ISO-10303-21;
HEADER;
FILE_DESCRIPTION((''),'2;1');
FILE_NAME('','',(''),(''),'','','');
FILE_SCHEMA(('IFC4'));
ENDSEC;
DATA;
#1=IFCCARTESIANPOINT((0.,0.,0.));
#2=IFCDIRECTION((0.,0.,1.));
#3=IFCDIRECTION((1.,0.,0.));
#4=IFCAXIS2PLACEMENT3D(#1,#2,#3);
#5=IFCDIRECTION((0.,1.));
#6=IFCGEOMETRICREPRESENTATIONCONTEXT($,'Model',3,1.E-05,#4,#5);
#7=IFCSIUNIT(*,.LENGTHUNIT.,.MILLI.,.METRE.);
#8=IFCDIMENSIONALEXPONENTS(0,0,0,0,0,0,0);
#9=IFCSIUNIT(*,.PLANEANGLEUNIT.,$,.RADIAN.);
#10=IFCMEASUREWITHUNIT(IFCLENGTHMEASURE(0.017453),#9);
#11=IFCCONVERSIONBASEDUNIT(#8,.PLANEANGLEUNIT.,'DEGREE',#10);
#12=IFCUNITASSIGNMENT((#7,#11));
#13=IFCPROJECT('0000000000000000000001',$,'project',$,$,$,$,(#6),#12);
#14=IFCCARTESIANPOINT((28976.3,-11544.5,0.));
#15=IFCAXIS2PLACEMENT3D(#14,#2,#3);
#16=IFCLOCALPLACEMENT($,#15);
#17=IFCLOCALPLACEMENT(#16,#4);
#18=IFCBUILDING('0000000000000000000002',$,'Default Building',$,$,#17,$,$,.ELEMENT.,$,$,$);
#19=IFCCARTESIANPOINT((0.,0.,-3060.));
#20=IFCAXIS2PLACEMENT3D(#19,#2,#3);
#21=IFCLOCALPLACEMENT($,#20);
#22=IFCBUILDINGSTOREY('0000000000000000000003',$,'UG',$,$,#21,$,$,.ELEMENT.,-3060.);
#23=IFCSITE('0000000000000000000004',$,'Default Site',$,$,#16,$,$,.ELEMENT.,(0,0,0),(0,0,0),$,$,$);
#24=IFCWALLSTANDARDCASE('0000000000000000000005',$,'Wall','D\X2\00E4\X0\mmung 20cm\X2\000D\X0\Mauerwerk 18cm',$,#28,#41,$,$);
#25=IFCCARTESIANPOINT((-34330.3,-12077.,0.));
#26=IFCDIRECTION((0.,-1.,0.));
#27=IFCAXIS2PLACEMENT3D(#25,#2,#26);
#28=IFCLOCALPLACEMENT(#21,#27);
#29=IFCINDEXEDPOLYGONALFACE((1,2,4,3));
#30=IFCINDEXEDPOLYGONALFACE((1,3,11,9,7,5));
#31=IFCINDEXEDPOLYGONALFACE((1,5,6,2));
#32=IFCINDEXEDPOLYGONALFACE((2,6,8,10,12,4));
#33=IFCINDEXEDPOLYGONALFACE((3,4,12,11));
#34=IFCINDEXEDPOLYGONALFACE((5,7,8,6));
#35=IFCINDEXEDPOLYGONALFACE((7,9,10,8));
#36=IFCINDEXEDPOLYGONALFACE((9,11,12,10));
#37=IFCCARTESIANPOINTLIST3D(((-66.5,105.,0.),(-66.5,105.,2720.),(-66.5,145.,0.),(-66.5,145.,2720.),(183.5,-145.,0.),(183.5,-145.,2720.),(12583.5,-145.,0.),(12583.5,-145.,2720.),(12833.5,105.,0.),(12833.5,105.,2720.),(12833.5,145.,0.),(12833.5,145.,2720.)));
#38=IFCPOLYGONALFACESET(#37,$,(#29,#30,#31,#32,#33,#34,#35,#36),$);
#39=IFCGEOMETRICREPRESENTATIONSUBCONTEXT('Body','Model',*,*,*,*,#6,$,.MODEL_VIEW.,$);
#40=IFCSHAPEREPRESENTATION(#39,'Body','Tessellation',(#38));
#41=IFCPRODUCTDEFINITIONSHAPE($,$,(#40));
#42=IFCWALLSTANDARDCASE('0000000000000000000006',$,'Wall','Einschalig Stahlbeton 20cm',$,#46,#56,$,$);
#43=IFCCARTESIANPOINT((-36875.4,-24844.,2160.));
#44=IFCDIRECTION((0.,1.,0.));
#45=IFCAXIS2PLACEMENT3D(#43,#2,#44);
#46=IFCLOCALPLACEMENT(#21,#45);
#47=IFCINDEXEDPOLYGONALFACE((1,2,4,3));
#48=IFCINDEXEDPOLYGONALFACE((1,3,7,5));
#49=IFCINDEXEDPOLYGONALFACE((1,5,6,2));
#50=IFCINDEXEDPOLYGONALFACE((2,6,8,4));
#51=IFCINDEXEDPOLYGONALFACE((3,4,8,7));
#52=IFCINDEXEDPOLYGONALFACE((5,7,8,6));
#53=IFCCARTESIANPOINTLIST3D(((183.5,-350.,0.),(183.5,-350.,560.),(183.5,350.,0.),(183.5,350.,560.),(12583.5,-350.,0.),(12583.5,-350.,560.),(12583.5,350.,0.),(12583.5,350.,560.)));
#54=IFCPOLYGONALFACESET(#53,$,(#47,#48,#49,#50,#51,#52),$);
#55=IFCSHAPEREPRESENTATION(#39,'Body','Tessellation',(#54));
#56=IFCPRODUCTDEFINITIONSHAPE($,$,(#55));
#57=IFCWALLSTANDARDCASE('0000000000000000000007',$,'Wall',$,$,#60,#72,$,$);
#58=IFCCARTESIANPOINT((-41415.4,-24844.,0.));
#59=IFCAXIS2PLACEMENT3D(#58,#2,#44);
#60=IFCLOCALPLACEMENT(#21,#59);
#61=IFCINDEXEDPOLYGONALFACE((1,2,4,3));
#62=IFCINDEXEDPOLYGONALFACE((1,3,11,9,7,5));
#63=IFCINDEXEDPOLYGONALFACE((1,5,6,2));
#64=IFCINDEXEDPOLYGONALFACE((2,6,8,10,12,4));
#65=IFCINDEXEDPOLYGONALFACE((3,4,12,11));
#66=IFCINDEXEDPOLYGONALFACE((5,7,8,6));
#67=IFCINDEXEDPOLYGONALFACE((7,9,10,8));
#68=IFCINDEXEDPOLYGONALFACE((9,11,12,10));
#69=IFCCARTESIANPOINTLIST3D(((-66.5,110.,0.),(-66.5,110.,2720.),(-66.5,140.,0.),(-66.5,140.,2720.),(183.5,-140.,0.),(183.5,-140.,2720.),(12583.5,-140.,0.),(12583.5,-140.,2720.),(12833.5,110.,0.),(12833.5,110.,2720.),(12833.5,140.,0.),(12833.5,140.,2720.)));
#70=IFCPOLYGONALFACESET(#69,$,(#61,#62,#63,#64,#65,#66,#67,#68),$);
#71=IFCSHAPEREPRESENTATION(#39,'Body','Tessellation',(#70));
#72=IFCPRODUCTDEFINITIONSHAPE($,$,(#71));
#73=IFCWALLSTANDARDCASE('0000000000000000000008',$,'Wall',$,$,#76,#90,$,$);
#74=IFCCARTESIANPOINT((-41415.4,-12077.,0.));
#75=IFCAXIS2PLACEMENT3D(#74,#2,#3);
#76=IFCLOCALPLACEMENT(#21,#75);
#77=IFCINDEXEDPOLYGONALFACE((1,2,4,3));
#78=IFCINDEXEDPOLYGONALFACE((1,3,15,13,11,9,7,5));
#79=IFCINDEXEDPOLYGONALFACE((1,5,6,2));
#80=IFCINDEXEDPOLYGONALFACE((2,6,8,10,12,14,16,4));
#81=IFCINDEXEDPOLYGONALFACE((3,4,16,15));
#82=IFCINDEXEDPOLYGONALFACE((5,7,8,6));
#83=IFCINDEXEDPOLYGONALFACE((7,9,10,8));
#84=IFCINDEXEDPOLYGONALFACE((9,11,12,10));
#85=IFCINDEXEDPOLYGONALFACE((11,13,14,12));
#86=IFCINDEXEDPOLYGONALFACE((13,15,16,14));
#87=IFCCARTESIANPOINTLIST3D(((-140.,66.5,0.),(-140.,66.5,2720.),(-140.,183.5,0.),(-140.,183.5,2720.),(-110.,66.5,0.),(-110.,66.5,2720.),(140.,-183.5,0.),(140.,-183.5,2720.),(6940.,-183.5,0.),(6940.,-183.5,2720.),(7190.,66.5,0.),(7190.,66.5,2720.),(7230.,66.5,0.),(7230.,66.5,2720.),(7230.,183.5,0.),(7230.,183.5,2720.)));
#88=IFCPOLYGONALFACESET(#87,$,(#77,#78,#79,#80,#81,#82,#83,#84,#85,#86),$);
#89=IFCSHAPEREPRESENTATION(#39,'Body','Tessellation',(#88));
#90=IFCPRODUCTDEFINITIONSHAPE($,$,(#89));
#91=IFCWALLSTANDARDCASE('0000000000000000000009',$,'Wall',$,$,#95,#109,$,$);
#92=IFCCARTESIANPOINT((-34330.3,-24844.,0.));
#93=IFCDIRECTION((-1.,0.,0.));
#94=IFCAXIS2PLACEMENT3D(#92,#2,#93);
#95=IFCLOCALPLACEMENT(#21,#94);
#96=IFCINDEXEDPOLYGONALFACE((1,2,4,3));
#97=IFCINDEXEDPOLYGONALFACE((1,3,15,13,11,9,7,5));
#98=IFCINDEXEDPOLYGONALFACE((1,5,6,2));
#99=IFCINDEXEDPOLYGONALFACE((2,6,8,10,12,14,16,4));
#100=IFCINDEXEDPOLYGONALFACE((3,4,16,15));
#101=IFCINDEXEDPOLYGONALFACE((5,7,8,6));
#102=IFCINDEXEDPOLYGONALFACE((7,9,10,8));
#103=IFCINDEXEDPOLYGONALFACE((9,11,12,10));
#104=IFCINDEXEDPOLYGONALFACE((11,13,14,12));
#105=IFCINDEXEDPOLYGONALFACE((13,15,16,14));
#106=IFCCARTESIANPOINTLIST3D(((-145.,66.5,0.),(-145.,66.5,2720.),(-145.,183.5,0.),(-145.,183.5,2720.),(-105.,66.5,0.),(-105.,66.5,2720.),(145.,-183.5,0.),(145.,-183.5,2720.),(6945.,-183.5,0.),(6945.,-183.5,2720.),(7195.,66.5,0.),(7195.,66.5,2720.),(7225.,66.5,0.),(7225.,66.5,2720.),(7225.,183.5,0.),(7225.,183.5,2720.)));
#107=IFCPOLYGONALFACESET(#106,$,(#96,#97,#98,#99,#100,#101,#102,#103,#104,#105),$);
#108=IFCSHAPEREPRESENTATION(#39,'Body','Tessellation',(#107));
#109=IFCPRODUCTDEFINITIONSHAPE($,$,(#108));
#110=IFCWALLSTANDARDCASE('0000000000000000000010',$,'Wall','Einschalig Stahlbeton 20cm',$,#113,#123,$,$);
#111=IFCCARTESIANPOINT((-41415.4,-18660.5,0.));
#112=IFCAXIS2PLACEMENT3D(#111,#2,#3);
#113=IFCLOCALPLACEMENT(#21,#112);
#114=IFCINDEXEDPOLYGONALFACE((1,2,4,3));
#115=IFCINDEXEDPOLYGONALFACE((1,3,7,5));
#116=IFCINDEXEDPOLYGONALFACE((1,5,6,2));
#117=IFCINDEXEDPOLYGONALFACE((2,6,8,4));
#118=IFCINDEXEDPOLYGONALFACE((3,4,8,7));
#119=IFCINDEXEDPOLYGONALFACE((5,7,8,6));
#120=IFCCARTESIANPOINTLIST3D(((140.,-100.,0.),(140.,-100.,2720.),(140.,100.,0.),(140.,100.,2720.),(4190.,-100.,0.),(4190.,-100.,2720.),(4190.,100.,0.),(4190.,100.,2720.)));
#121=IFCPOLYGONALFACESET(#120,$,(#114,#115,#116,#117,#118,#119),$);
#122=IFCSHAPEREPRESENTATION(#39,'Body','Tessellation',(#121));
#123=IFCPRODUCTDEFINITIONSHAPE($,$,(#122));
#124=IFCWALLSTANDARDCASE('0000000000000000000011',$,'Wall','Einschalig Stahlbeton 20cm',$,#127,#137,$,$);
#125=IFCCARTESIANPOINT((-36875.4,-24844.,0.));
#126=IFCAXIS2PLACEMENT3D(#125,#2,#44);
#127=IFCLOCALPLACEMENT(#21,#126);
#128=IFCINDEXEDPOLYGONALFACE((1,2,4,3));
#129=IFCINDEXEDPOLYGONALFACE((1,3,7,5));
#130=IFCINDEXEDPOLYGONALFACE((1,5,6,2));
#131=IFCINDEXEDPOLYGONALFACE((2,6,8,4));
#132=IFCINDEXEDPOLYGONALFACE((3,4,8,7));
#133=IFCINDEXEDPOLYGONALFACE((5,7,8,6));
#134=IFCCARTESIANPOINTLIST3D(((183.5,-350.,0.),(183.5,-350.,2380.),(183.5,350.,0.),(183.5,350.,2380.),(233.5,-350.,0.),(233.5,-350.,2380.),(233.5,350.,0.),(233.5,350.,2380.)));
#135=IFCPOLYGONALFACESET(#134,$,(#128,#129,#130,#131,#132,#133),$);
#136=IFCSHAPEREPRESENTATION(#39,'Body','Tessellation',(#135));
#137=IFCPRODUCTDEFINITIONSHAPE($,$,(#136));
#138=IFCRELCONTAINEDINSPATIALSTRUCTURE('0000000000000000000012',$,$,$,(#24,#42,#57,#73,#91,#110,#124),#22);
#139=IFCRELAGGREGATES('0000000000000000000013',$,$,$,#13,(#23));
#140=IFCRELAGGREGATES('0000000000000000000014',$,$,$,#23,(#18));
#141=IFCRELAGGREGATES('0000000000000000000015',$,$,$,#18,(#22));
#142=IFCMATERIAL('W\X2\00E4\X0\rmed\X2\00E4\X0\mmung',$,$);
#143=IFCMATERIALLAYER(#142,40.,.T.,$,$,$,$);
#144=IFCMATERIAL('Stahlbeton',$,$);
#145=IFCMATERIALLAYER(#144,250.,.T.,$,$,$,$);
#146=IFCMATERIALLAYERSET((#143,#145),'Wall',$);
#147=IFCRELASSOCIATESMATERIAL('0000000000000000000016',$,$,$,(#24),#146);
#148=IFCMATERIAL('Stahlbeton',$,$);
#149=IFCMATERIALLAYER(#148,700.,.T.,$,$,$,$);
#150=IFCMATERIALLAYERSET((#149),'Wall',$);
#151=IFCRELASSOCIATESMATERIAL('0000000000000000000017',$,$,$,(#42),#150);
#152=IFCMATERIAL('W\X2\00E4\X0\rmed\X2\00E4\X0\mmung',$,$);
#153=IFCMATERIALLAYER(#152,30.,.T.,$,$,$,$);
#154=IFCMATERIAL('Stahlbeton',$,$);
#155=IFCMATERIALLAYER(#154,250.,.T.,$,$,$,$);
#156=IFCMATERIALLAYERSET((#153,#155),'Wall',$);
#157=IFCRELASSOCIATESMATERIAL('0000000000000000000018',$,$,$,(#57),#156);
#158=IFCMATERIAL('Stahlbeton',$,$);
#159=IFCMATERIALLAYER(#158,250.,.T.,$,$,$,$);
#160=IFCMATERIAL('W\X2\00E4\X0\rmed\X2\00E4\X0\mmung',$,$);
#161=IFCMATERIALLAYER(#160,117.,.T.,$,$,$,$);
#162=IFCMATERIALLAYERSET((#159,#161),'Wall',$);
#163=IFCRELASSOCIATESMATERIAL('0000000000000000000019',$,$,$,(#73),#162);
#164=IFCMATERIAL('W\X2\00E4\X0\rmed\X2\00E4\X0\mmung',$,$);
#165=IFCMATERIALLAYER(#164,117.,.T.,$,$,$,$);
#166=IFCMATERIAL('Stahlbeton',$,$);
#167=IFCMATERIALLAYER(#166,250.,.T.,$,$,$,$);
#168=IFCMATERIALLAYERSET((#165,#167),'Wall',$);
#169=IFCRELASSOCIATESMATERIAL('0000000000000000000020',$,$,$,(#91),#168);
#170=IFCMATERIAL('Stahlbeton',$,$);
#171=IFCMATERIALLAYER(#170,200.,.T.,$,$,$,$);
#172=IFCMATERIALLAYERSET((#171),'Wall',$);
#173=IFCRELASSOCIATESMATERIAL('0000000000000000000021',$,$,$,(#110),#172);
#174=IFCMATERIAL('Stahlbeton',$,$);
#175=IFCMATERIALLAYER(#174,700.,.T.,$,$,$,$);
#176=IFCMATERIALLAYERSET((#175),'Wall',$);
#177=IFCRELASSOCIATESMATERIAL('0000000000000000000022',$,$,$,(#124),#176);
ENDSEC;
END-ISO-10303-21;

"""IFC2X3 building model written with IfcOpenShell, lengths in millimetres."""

from ifc_helpers import new_model, entity, si_unit, converted_unit, direction, frame, origin_with_axes, place, context, subcontext, project, spatial, polyline, outline, extrude, material, layer, layer_set, layer_usage, element, save


model = new_model("IFC2X3")

# Units and contexts
model_context = context("Model", 3, precision=1e-05, world=origin_with_axes(), true_north=direction((0.0, 1.0)))
body_context = subcontext(model_context, "Body", "Model", "MODEL_VIEW")
ifc_project = project(units=[si_unit("LENGTHUNIT", "METRE", prefix="MILLI"), converted_unit("PLANEANGLEUNIT", "DEGREE", entity("IfcLengthMeasure", 0.017453), si_unit("PLANEANGLEUNIT", "RADIAN"), dimensions=[0, 0, 0, 0, 0, 0, 0])], contexts=[model_context])

# Site, building, storey
site_placement = place(None, frame((28976.3, -11544.5, 0.0), z_axis=(0.0, 0.0, 1.0), x_axis=(1.0, 0.0, 0.0)))
site = spatial("IfcSite", under=ifc_project, at=site_placement, Name="Default Site", CompositionType="ELEMENT", RefLatitude=(0, 0, 0), RefLongitude=(0, 0, 0))
building_placement = place(site_placement, origin_with_axes())
building = spatial("IfcBuilding", under=site, at=building_placement, Name="Default Building", CompositionType="ELEMENT")
storey_placement = place(None, frame((0.0, 0.0, -3060.0), z_axis=(0.0, 0.0, 1.0), x_axis=(1.0, 0.0, 0.0)))
storey = spatial("IfcBuildingStorey", under=building, at=storey_placement, Name="UG", CompositionType="ELEMENT", Elevation=-3060.0)

# Walls
ifc_material_1 = material(Name="Wärmedämmung")
ifc_layer_1 = layer(ifc_material_1, 40.0, ventilated=True)
ifc_material_2 = material(Name="Stahlbeton")
ifc_layer_2 = layer(ifc_material_2, 250.0, ventilated=True)
ifc_layer_set_1 = layer_set([ifc_layer_1, ifc_layer_2], Name="Wall")
ifc_layer_usage_1 = layer_usage(ifc_layer_set_1, "AXIS2", "POSITIVE", -145.0)
wall_1_placement = place(storey_placement, frame((-34330.3, -12077.0, 0.0), z_axis=(0.0, 0.0, 1.0), x_axis=(0.0, -1.0, 0.0)))
element("IfcWallStandardCase", 1, at=wall_1_placement, inside=storey, material=ifc_layer_usage_1, Name="Wall", Description="Dämmung 20cm\rMauerwerk 18cm", context=body_context, shape_type="SweptSolid", body=[
    extrude(outline(polyline([(12833.5, 105.0), (12833.5, 145.0), (-66.5, 145.0), (-66.5, 105.0), (183.5, -145.0), (12583.5, -145.0), (12833.5, 105.0)])), origin_with_axes(), (0.0, 0.0, 1.0), 2720.0),
])
ifc_material_3 = material(Name="Stahlbeton")
ifc_layer_3 = layer(ifc_material_3, 700.0, ventilated=True)
ifc_layer_set_2 = layer_set([ifc_layer_3], Name="Wall")
ifc_layer_usage_2 = layer_usage(ifc_layer_set_2, "AXIS2", "POSITIVE", -350.0)
wall_2_placement = place(storey_placement, frame((-36875.4, -24844.0, 2160.0), z_axis=(0.0, 0.0, 1.0), x_axis=(0.0, 1.0, 0.0)))
element("IfcWallStandardCase", 2, at=wall_2_placement, inside=storey, material=ifc_layer_usage_2, Name="Wall", Description="Einschalig Stahlbeton 20cm", context=body_context, shape_type="SweptSolid", body=[
    extrude(outline(polyline([(183.5, -350.0), (183.5, 350.0), (12583.5, 350.0), (12583.5, -350.0), (183.5, -350.0)])), origin_with_axes(), (0.0, 0.0, 1.0), 560.0),
])
ifc_material_4 = material(Name="Wärmedämmung")
ifc_layer_4 = layer(ifc_material_4, 30.0, ventilated=True)
ifc_material_5 = material(Name="Stahlbeton")
ifc_layer_5 = layer(ifc_material_5, 250.0, ventilated=True)
ifc_layer_set_3 = layer_set([ifc_layer_4, ifc_layer_5], Name="Wall")
ifc_layer_usage_3 = layer_usage(ifc_layer_set_3, "AXIS2", "POSITIVE", -140.0)
wall_3_placement = place(storey_placement, frame((-41415.4, -24844.0, 0.0), z_axis=(0.0, 0.0, 1.0), x_axis=(0.0, 1.0, 0.0)))
element("IfcWallStandardCase", 3, at=wall_3_placement, inside=storey, material=ifc_layer_usage_3, Name="Wall", context=body_context, shape_type="SweptSolid", body=[
    extrude(outline(polyline([(12833.5, 110.0), (12833.5, 140.0), (-66.5, 140.0), (-66.5, 110.0), (183.5, -140.0), (12583.5, -140.0), (12833.5, 110.0)])), origin_with_axes(), (0.0, 0.0, 1.0), 2720.0),
])

# Walls
ifc_material_6 = material(Name="Stahlbeton")
ifc_layer_6 = layer(ifc_material_6, 250.0, ventilated=True)
ifc_material_7 = material(Name="Wärmedämmung")
ifc_layer_7 = layer(ifc_material_7, 117.0, ventilated=True)
ifc_layer_set_4 = layer_set([ifc_layer_6, ifc_layer_7], Name="Wall")
ifc_layer_usage_4 = layer_usage(ifc_layer_set_4, "AXIS2", "POSITIVE", -183.5)
wall_4_placement = place(storey_placement, frame((-41415.4, -12077.0, 0.0), z_axis=(0.0, 0.0, 1.0), x_axis=(1.0, 0.0, 0.0)))
element("IfcWallStandardCase", 4, at=wall_4_placement, inside=storey, material=ifc_layer_usage_4, Name="Wall", context=body_context, shape_type="SweptSolid", body=[
    extrude(outline(polyline([(7190.0, 66.5), (7230.0, 66.5), (7230.0, 183.5), (-140.0, 183.5), (-140.0, 66.5), (-110.0, 66.5), (140.0, -183.5), (6940.0, -183.5), (7190.0, 66.5)])), origin_with_axes(), (0.0, 0.0, 1.0), 2720.0),
])
ifc_material_8 = material(Name="Wärmedämmung")
ifc_layer_8 = layer(ifc_material_8, 117.0, ventilated=True)
ifc_material_9 = material(Name="Stahlbeton")
ifc_layer_9 = layer(ifc_material_9, 250.0, ventilated=True)
ifc_layer_set_5 = layer_set([ifc_layer_8, ifc_layer_9], Name="Wall")
ifc_layer_usage_5 = layer_usage(ifc_layer_set_5, "AXIS2", "POSITIVE", -183.5)
wall_5_placement = place(storey_placement, frame((-34330.3, -24844.0, 0.0), z_axis=(0.0, 0.0, 1.0), x_axis=(-1.0, 0.0, 0.0)))
element("IfcWallStandardCase", 5, at=wall_5_placement, inside=storey, material=ifc_layer_usage_5, Name="Wall", context=body_context, shape_type="SweptSolid", body=[
    extrude(outline(polyline([(7195.0, 66.5), (7225.0, 66.5), (7225.0, 183.5), (-145.0, 183.5), (-145.0, 66.5), (-105.0, 66.5), (145.0, -183.5), (6945.0, -183.5), (7195.0, 66.5)])), origin_with_axes(), (0.0, 0.0, 1.0), 2720.0),
])
ifc_material_10 = material(Name="Stahlbeton")
ifc_layer_10 = layer(ifc_material_10, 200.0, ventilated=True)
ifc_layer_set_6 = layer_set([ifc_layer_10], Name="Wall")
ifc_layer_usage_6 = layer_usage(ifc_layer_set_6, "AXIS2", "POSITIVE", -100.0)
wall_6_placement = place(storey_placement, frame((-41415.4, -18660.5, 0.0), z_axis=(0.0, 0.0, 1.0), x_axis=(1.0, 0.0, 0.0)))
element("IfcWallStandardCase", 6, at=wall_6_placement, inside=storey, material=ifc_layer_usage_6, Name="Wall", Description="Einschalig Stahlbeton 20cm", context=body_context, shape_type="SweptSolid", body=[
    extrude(outline(polyline([(4190.0, -100.0), (4190.0, 100.0), (140.0, 100.0), (140.0, -100.0), (4190.0, -100.0)])), origin_with_axes(), (0.0, 0.0, 1.0), 2720.0),
])
ifc_material_11 = material(Name="Stahlbeton")
ifc_layer_11 = layer(ifc_material_11, 700.0, ventilated=True)
ifc_layer_set_7 = layer_set([ifc_layer_11], Name="Wall")
ifc_layer_usage_7 = layer_usage(ifc_layer_set_7, "AXIS2", "POSITIVE", -350.0)
wall_7_placement = place(storey_placement, frame((-36875.4, -24844.0, 0.0), z_axis=(0.0, 0.0, 1.0), x_axis=(0.0, 1.0, 0.0)))
element("IfcWallStandardCase", 7, at=wall_7_placement, inside=storey, material=ifc_layer_usage_7, Name="Wall", Description="Einschalig Stahlbeton 20cm", context=body_context, shape_type="SweptSolid", body=[
    extrude(outline(polyline([(233.5, 350.0), (183.5, 350.0), (183.5, -350.0), (233.5, -350.0), (233.5, 350.0)])), origin_with_axes(), (0.0, 0.0, 1.0), 2380.0),
])

save(model, "model.ifc")
